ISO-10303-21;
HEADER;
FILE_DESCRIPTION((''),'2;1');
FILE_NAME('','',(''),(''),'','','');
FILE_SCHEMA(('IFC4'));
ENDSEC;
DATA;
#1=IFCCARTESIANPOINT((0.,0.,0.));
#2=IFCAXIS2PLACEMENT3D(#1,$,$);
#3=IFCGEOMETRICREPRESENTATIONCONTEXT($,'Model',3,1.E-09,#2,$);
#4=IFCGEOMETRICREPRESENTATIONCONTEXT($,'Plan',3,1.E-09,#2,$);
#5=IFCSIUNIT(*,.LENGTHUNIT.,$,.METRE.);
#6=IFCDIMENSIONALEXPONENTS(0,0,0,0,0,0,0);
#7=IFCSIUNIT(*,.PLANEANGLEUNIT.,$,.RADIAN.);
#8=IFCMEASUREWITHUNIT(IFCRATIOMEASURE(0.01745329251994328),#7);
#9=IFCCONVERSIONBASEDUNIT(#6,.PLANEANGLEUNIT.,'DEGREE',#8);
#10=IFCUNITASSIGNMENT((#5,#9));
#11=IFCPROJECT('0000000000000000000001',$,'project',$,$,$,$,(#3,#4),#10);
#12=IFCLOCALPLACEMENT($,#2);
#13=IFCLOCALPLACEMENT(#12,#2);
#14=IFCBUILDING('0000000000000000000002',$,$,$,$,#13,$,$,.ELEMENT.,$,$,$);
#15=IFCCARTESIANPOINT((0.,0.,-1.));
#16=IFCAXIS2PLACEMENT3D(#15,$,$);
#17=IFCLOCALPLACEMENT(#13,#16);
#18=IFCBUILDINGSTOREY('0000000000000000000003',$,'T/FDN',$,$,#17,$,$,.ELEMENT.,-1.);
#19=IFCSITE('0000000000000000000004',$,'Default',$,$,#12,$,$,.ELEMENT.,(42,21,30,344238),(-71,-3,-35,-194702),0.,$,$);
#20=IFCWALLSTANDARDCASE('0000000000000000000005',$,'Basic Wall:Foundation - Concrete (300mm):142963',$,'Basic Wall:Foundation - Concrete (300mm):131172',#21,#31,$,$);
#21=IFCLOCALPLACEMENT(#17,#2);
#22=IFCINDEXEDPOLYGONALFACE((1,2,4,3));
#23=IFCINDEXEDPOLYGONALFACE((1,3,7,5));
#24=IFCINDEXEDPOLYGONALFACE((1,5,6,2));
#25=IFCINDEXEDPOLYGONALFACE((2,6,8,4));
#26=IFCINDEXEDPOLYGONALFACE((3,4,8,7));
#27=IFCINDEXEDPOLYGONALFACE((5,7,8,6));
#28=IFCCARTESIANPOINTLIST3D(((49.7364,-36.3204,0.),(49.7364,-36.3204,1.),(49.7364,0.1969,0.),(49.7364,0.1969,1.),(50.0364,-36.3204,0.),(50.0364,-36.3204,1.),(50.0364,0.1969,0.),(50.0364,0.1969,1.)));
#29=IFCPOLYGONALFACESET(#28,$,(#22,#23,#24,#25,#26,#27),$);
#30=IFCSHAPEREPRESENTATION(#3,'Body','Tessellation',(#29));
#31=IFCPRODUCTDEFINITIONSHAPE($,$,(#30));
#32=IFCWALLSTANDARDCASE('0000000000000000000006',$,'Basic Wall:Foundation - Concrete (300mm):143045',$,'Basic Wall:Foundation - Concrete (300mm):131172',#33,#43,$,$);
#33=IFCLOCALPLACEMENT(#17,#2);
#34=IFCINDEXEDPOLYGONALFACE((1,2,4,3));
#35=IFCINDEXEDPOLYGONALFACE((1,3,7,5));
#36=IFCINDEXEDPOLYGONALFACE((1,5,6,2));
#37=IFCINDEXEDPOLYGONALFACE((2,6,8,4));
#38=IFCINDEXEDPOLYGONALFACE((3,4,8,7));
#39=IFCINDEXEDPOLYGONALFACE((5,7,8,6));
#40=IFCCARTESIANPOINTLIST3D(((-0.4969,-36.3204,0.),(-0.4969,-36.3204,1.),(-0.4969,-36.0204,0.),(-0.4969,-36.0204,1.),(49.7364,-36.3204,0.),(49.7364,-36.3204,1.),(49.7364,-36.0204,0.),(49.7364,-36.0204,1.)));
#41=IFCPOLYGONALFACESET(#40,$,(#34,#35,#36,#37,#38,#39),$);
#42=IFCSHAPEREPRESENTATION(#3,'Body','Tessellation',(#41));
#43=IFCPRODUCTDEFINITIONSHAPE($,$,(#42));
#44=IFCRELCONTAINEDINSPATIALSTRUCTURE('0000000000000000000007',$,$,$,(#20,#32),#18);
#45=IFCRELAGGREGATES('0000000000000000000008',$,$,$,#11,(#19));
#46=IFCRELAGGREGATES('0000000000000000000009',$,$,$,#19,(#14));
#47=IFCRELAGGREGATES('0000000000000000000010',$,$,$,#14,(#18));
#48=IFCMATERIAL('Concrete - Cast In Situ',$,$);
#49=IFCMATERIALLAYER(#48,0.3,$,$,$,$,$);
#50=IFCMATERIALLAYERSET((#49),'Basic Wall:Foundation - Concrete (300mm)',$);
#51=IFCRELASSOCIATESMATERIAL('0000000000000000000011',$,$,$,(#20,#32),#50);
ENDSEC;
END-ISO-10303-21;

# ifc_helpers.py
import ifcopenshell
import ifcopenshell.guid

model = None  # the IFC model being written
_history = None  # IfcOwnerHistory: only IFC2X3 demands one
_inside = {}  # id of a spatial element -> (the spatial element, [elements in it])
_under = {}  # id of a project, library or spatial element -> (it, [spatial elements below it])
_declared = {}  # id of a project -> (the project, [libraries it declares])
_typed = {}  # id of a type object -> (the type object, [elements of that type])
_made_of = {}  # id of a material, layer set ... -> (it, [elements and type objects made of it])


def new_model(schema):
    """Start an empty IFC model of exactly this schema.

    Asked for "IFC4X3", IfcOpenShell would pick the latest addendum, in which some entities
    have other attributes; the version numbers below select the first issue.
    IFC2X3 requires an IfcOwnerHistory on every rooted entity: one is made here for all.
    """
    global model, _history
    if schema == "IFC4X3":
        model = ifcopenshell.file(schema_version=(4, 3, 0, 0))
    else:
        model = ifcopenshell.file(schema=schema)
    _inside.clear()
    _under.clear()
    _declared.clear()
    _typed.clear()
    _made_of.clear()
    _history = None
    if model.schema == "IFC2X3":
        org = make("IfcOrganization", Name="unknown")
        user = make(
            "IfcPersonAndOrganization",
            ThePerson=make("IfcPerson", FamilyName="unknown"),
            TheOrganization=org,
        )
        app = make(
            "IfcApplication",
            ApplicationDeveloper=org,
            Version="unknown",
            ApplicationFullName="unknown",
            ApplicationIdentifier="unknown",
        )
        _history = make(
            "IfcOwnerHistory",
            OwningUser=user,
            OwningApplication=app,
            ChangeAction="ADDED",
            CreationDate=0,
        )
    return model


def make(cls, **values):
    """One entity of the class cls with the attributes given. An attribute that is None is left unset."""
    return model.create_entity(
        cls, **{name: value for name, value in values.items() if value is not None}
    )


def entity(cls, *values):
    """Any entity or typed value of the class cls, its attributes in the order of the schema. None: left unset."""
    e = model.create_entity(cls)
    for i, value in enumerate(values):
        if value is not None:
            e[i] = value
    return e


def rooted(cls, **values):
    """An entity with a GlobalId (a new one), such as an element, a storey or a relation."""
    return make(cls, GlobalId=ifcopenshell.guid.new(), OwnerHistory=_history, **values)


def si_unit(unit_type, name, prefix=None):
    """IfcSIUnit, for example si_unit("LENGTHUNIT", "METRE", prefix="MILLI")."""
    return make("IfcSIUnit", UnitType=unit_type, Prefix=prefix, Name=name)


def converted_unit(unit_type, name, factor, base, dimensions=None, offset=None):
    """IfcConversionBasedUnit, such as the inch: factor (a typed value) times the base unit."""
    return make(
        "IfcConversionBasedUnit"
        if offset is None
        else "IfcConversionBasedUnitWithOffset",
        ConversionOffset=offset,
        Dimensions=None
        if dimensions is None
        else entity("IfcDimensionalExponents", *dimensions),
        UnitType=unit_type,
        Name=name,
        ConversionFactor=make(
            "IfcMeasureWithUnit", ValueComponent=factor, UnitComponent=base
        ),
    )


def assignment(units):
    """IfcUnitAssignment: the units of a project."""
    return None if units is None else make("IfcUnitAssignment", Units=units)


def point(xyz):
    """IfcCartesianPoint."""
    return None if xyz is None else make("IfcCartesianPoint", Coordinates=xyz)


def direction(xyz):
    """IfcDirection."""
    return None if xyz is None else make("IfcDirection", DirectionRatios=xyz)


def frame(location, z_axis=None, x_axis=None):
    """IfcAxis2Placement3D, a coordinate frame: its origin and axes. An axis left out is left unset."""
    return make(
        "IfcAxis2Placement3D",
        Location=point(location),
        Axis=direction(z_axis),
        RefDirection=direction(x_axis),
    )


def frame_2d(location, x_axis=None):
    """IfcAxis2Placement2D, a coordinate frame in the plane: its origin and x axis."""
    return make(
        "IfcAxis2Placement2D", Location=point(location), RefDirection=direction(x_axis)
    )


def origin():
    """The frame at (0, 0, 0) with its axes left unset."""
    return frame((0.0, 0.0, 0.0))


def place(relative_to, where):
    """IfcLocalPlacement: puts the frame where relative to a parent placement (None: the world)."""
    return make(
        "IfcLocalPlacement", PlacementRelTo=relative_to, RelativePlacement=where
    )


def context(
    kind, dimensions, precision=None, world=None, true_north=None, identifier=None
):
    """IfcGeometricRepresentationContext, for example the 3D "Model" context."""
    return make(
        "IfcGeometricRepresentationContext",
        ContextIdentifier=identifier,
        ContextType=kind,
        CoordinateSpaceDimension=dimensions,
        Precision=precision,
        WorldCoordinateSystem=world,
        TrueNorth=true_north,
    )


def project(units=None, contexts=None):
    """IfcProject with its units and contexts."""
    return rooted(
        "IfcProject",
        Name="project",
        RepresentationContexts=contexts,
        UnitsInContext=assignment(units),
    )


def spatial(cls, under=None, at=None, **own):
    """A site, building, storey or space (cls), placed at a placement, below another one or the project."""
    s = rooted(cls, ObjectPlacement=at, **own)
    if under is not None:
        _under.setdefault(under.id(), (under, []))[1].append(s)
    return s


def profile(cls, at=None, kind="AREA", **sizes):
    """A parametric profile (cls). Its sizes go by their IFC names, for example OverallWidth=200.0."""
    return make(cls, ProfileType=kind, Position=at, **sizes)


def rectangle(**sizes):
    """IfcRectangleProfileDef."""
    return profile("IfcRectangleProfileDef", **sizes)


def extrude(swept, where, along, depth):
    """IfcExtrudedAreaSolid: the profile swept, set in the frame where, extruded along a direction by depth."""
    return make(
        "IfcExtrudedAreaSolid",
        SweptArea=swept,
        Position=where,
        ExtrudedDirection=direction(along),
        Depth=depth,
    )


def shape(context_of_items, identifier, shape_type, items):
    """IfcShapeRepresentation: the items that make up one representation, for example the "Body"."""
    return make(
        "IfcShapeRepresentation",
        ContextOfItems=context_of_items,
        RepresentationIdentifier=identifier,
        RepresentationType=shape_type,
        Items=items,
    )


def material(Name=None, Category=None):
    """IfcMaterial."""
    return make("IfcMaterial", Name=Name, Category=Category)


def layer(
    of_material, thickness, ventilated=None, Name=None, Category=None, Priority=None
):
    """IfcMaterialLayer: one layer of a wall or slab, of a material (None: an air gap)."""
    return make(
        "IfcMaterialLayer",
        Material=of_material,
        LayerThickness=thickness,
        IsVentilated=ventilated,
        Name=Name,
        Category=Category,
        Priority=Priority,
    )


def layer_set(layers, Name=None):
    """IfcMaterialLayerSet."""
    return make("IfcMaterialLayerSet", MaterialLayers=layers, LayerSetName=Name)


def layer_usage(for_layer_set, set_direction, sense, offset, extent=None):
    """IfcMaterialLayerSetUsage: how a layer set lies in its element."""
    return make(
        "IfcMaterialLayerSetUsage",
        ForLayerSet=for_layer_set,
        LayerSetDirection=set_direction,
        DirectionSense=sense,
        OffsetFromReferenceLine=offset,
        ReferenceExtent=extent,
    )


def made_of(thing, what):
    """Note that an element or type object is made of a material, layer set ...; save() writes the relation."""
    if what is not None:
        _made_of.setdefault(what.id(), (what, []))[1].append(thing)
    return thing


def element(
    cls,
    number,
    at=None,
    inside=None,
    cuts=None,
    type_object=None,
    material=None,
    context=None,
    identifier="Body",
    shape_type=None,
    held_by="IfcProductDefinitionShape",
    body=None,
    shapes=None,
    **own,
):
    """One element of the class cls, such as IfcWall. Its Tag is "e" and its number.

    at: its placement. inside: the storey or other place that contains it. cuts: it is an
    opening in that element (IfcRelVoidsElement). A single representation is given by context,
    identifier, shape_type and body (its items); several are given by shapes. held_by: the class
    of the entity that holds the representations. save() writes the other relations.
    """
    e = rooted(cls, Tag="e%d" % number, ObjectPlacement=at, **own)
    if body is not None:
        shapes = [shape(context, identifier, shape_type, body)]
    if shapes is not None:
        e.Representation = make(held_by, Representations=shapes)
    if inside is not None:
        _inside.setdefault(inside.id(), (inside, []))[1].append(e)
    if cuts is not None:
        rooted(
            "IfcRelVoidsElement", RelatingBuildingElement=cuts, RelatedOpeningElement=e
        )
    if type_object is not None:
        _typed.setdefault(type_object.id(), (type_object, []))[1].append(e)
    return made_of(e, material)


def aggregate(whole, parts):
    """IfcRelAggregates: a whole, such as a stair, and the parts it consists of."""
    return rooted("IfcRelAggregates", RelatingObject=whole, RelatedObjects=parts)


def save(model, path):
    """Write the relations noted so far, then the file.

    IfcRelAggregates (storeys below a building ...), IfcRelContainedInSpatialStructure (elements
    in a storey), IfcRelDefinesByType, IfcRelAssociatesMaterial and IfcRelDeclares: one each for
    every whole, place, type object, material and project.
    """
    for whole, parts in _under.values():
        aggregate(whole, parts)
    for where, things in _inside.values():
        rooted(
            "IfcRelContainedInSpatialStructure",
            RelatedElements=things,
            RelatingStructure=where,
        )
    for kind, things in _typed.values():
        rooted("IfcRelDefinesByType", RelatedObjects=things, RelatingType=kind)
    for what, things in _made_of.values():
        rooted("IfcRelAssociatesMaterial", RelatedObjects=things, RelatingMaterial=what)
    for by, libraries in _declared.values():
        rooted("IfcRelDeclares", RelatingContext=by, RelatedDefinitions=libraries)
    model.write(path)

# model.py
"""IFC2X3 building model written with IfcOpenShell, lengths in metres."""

from ifc_helpers import new_model, entity, si_unit, converted_unit, frame, frame_2d, origin, place, context, project, spatial, rectangle, extrude, material, layer, layer_set, layer_usage, element, save


model = new_model("IFC2X3")

# Units and contexts
model_context = context("Model", 3, precision=1e-09, world=origin())
plan_context = context("Plan", 3, precision=1e-09, world=origin())
ifc_project = project(units=[si_unit("LENGTHUNIT", "METRE"), converted_unit("PLANEANGLEUNIT", "DEGREE", entity("IfcRatioMeasure", 0.01745329251994328), si_unit("PLANEANGLEUNIT", "RADIAN"), dimensions=[0, 0, 0, 0, 0, 0, 0])], contexts=[model_context, plan_context])

# Site, building, storey
site_placement = place(None, origin())
site = spatial("IfcSite", under=ifc_project, at=site_placement, Name="Default", CompositionType="ELEMENT", RefLatitude=(42, 21, 30, 344238), RefLongitude=(-71, -3, -35, -194702), RefElevation=0.0)
building_placement = place(site_placement, origin())
building = spatial("IfcBuilding", under=site, at=building_placement, CompositionType="ELEMENT")
storey_placement = place(building_placement, frame((0.0, 0.0, -1.0)))
storey = spatial("IfcBuildingStorey", under=building, at=storey_placement, Name="T/FDN", CompositionType="ELEMENT", Elevation=-1.0)

# Walls
ifc_material_1 = material(Name="Concrete - Cast In Situ")
ifc_layer = layer(ifc_material_1, 0.3)
ifc_layer_set = layer_set([ifc_layer], Name="Basic Wall:Foundation - Concrete (300mm)")
ifc_layer_usage = layer_usage(ifc_layer_set, "AXIS2", "NEGATIVE", 0.15)
wall_1_placement = place(storey_placement, frame((49.8864, 0.1969, 0.0), z_axis=(0.0, 0.0, 1.0), x_axis=(0.0, -1.0, 0.0)))
element("IfcWallStandardCase", 1, at=wall_1_placement, inside=storey, material=ifc_layer_usage, Name="Basic Wall:Foundation - Concrete (300mm):142963", ObjectType="Basic Wall:Foundation - Concrete (300mm):131172", context=model_context, shape_type="SweptSolid", body=[
    extrude(rectangle(XDim=36.5173, YDim=0.3, at=frame_2d((18.2586, 0.0), x_axis=(-1.0, 0.0))), origin(), (0.0, 0.0, 1.0), 1.0),
])
wall_2_placement = place(storey_placement, frame((49.7364, -36.1704, 0.0), z_axis=(0.0, 0.0, 1.0), x_axis=(-1.0, 0.0, 0.0)))
element("IfcWallStandardCase", 2, at=wall_2_placement, inside=storey, material=ifc_layer_usage, Name="Basic Wall:Foundation - Concrete (300mm):143045", ObjectType="Basic Wall:Foundation - Concrete (300mm):131172", context=model_context, shape_type="SweptSolid", body=[
    extrude(rectangle(XDim=50.2333, YDim=0.3, at=frame_2d((25.1166, 0.0), x_axis=(-1.0, 0.0))), origin(), (0.0, 0.0, 1.0), 1.0),
])

save(model, "model.ifc")
